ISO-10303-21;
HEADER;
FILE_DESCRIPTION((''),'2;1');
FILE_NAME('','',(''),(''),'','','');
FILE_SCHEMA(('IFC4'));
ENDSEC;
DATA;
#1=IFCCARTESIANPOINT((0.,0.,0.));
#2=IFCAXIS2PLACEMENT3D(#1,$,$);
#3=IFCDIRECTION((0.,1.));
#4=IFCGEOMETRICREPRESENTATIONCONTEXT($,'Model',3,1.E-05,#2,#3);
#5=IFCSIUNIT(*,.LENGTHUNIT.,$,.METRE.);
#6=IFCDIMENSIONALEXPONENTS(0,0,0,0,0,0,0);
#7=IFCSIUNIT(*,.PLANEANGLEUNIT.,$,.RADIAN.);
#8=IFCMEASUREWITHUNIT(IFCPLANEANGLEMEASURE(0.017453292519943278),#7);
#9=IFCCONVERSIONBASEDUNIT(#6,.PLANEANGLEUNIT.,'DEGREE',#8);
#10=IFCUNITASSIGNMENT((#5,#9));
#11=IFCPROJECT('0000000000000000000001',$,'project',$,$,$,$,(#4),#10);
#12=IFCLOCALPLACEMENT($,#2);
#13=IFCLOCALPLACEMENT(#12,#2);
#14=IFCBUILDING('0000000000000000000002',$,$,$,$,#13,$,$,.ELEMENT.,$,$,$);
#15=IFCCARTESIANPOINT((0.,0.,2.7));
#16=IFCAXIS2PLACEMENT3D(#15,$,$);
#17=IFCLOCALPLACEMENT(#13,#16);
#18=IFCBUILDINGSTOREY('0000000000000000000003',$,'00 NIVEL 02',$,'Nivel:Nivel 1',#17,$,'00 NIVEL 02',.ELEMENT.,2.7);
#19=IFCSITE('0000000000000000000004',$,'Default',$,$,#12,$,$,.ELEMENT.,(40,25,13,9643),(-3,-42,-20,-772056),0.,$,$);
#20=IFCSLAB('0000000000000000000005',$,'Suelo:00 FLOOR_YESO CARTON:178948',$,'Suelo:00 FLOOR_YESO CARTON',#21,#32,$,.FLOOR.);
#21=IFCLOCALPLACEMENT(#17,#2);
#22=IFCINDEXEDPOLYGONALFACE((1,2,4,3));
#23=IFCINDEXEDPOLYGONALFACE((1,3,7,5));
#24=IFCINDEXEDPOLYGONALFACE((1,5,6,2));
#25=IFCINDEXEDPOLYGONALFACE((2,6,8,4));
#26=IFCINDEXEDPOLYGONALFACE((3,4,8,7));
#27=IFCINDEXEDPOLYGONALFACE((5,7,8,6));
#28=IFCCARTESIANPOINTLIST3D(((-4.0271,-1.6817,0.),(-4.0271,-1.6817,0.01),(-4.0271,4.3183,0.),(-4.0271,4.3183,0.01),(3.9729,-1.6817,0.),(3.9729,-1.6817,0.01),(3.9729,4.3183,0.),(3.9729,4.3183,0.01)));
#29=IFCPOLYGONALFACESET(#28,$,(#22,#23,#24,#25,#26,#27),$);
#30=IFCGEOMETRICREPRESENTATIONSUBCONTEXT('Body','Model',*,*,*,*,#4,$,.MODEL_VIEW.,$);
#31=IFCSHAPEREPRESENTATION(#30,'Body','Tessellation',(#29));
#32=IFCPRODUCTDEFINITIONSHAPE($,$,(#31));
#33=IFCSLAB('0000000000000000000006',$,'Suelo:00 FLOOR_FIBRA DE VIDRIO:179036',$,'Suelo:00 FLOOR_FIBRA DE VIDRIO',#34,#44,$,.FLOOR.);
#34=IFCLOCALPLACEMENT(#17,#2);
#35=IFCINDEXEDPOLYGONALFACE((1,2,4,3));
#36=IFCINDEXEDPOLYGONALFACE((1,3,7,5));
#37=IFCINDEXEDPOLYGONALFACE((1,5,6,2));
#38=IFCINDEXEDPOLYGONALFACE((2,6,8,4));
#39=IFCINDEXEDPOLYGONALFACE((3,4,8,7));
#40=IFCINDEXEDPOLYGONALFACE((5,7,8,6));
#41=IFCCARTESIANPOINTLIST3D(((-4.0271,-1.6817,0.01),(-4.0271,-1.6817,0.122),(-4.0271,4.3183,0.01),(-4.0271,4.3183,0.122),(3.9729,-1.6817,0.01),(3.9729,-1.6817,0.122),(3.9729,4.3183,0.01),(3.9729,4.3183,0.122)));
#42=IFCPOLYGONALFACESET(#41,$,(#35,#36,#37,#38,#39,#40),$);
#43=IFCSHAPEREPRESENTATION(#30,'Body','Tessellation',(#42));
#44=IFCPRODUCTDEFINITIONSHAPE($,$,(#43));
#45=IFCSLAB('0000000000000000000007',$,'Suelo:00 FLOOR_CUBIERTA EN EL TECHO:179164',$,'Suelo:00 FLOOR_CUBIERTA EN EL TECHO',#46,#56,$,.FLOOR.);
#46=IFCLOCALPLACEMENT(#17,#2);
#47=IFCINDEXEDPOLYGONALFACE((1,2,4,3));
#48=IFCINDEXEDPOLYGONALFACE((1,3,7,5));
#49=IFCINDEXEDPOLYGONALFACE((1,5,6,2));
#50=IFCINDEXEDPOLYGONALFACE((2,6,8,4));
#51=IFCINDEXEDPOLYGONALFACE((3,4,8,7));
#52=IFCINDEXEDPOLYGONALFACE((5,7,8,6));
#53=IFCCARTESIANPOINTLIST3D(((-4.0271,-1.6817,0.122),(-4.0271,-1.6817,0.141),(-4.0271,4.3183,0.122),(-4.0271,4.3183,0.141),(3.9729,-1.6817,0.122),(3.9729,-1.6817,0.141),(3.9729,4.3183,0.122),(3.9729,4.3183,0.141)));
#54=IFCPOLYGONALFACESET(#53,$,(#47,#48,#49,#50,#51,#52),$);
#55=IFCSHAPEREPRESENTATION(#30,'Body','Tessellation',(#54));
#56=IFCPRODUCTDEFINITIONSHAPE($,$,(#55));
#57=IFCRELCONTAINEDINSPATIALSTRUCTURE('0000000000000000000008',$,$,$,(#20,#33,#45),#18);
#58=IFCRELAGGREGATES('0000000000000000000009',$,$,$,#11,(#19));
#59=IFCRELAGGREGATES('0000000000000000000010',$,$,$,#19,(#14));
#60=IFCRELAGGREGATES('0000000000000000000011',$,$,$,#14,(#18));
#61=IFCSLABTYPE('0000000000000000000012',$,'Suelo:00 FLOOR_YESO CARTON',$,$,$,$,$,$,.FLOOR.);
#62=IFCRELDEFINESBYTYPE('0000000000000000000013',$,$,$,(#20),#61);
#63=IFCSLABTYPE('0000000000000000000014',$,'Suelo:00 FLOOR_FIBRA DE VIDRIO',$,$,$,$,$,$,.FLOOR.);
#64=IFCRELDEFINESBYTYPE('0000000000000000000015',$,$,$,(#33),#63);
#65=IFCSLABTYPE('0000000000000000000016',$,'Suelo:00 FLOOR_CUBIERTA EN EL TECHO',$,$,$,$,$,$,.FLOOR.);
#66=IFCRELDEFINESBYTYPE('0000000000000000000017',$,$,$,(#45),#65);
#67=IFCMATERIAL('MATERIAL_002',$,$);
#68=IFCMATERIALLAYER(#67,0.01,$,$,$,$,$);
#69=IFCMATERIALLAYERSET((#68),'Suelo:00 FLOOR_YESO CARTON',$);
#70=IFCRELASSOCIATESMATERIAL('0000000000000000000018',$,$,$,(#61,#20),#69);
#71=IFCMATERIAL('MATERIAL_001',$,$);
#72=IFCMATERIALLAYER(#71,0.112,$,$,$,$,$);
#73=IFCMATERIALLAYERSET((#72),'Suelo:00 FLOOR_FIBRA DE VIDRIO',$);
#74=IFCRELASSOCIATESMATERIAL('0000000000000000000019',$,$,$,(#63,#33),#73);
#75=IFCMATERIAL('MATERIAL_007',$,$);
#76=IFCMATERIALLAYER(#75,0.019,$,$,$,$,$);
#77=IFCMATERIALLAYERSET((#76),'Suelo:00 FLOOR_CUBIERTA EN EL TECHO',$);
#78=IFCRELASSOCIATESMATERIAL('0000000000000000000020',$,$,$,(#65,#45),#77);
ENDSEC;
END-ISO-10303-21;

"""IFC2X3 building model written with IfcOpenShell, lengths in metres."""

from ifc_helpers import new_model, entity, si_unit, converted_unit, direction, frame, origin, origin_2d_with_axis, place, context, subcontext, project, spatial, rectangle, extrude, material, layer, layer_set, layer_usage, type_object, element, save


model = new_model("IFC2X3")

# Units and contexts
model_context = context("Model", 3, precision=1e-05, world=origin(), true_north=direction((0.0, 1.0)))
body_context = subcontext(model_context, "Body", "Model", "MODEL_VIEW")
ifc_project = project(units=[si_unit("LENGTHUNIT", "METRE"), converted_unit("PLANEANGLEUNIT", "DEGREE", entity("IfcPlaneAngleMeasure", 0.017453292519943278), si_unit("PLANEANGLEUNIT", "RADIAN"), dimensions=[0, 0, 0, 0, 0, 0, 0])], contexts=[model_context])

# Site, building, storey
site_placement = place(None, origin())
site = spatial("IfcSite", under=ifc_project, at=site_placement, Name="Default", CompositionType="ELEMENT", RefLatitude=(40, 25, 13, 9643), RefLongitude=(-3, -42, -20, -772056), RefElevation=0.0)
building_placement = place(site_placement, origin())
building = spatial("IfcBuilding", under=site, at=building_placement, CompositionType="ELEMENT")
storey_placement = place(building_placement, frame((0.0, 0.0, 2.7)))
storey = spatial("IfcBuildingStorey", under=building, at=storey_placement, Name="00 NIVEL 02", ObjectType="Nivel:Nivel 1", LongName="00 NIVEL 02", CompositionType="ELEMENT", Elevation=2.7)

# Slabs
ifc_material_1 = material(Name="MATERIAL_002")
ifc_layer_1 = layer(ifc_material_1, 0.01)
ifc_layer_set_1 = layer_set([ifc_layer_1], Name="Suelo:00 FLOOR_YESO CARTON")
ifc_layer_usage_1 = layer_usage(ifc_layer_set_1, "AXIS3", "POSITIVE", 0.0)
slab_type_1 = type_object("IfcSlabType", Name="Suelo:00 FLOOR_YESO CARTON", PredefinedType="FLOOR", material=ifc_layer_set_1)
slab_1_placement = place(storey_placement, origin())
element("IfcSlab", 1, at=slab_1_placement, inside=storey, type_object=slab_type_1, material=ifc_layer_usage_1, Name="Suelo:00 FLOOR_YESO CARTON:178948", ObjectType="Suelo:00 FLOOR_YESO CARTON", PredefinedType="FLOOR", context=body_context, shape_type="SweptSolid", body=[
    extrude(rectangle(XDim=6.0, YDim=8.0, at=origin_2d_with_axis()), frame((-0.0271, 1.3183, 0.01), z_axis=(0.0, 0.0, -1.0), x_axis=(0.0, 1.0, 0.0)), (0.0, 0.0, 1.0), 0.01),
])
ifc_material_2 = material(Name="MATERIAL_001")
ifc_layer_2 = layer(ifc_material_2, 0.112)
ifc_layer_set_2 = layer_set([ifc_layer_2], Name="Suelo:00 FLOOR_FIBRA DE VIDRIO")
ifc_layer_usage_2 = layer_usage(ifc_layer_set_2, "AXIS3", "POSITIVE", 0.0)
slab_type_2 = type_object("IfcSlabType", Name="Suelo:00 FLOOR_FIBRA DE VIDRIO", PredefinedType="FLOOR", material=ifc_layer_set_2)
slab_2_placement = place(storey_placement, origin())
element("IfcSlab", 2, at=slab_2_placement, inside=storey, type_object=slab_type_2, material=ifc_layer_usage_2, Name="Suelo:00 FLOOR_FIBRA DE VIDRIO:179036", ObjectType="Suelo:00 FLOOR_FIBRA DE VIDRIO", PredefinedType="FLOOR", context=body_context, shape_type="SweptSolid", body=[
    extrude(rectangle(XDim=6.0, YDim=8.0, at=origin_2d_with_axis()), frame((-0.0271, 1.3183, 0.122), z_axis=(0.0, 0.0, -1.0), x_axis=(0.0, 1.0, 0.0)), (0.0, 0.0, 1.0), 0.112),
])
ifc_material_3 = material(Name="MATERIAL_007")
ifc_layer_3 = layer(ifc_material_3, 0.019)
ifc_layer_set_3 = layer_set([ifc_layer_3], Name="Suelo:00 FLOOR_CUBIERTA EN EL TECHO")
ifc_layer_usage_3 = layer_usage(ifc_layer_set_3, "AXIS3", "POSITIVE", 0.0)
slab_type_3 = type_object("IfcSlabType", Name="Suelo:00 FLOOR_CUBIERTA EN EL TECHO", PredefinedType="FLOOR", material=ifc_layer_set_3)
slab_3_placement = place(storey_placement, origin())
element("IfcSlab", 3, at=slab_3_placement, inside=storey, type_object=slab_type_3, material=ifc_layer_usage_3, Name="Suelo:00 FLOOR_CUBIERTA EN EL TECHO:179164", ObjectType="Suelo:00 FLOOR_CUBIERTA EN EL TECHO", PredefinedType="FLOOR", context=body_context, shape_type="SweptSolid", body=[
    extrude(rectangle(XDim=6.0, YDim=8.0, at=origin_2d_with_axis()), frame((-0.0271, 1.3183, 0.141), z_axis=(0.0, 0.0, -1.0), x_axis=(0.0, 1.0, 0.0)), (0.0, 0.0, 1.0), 0.019),
])

save(model, "model.ifc")
